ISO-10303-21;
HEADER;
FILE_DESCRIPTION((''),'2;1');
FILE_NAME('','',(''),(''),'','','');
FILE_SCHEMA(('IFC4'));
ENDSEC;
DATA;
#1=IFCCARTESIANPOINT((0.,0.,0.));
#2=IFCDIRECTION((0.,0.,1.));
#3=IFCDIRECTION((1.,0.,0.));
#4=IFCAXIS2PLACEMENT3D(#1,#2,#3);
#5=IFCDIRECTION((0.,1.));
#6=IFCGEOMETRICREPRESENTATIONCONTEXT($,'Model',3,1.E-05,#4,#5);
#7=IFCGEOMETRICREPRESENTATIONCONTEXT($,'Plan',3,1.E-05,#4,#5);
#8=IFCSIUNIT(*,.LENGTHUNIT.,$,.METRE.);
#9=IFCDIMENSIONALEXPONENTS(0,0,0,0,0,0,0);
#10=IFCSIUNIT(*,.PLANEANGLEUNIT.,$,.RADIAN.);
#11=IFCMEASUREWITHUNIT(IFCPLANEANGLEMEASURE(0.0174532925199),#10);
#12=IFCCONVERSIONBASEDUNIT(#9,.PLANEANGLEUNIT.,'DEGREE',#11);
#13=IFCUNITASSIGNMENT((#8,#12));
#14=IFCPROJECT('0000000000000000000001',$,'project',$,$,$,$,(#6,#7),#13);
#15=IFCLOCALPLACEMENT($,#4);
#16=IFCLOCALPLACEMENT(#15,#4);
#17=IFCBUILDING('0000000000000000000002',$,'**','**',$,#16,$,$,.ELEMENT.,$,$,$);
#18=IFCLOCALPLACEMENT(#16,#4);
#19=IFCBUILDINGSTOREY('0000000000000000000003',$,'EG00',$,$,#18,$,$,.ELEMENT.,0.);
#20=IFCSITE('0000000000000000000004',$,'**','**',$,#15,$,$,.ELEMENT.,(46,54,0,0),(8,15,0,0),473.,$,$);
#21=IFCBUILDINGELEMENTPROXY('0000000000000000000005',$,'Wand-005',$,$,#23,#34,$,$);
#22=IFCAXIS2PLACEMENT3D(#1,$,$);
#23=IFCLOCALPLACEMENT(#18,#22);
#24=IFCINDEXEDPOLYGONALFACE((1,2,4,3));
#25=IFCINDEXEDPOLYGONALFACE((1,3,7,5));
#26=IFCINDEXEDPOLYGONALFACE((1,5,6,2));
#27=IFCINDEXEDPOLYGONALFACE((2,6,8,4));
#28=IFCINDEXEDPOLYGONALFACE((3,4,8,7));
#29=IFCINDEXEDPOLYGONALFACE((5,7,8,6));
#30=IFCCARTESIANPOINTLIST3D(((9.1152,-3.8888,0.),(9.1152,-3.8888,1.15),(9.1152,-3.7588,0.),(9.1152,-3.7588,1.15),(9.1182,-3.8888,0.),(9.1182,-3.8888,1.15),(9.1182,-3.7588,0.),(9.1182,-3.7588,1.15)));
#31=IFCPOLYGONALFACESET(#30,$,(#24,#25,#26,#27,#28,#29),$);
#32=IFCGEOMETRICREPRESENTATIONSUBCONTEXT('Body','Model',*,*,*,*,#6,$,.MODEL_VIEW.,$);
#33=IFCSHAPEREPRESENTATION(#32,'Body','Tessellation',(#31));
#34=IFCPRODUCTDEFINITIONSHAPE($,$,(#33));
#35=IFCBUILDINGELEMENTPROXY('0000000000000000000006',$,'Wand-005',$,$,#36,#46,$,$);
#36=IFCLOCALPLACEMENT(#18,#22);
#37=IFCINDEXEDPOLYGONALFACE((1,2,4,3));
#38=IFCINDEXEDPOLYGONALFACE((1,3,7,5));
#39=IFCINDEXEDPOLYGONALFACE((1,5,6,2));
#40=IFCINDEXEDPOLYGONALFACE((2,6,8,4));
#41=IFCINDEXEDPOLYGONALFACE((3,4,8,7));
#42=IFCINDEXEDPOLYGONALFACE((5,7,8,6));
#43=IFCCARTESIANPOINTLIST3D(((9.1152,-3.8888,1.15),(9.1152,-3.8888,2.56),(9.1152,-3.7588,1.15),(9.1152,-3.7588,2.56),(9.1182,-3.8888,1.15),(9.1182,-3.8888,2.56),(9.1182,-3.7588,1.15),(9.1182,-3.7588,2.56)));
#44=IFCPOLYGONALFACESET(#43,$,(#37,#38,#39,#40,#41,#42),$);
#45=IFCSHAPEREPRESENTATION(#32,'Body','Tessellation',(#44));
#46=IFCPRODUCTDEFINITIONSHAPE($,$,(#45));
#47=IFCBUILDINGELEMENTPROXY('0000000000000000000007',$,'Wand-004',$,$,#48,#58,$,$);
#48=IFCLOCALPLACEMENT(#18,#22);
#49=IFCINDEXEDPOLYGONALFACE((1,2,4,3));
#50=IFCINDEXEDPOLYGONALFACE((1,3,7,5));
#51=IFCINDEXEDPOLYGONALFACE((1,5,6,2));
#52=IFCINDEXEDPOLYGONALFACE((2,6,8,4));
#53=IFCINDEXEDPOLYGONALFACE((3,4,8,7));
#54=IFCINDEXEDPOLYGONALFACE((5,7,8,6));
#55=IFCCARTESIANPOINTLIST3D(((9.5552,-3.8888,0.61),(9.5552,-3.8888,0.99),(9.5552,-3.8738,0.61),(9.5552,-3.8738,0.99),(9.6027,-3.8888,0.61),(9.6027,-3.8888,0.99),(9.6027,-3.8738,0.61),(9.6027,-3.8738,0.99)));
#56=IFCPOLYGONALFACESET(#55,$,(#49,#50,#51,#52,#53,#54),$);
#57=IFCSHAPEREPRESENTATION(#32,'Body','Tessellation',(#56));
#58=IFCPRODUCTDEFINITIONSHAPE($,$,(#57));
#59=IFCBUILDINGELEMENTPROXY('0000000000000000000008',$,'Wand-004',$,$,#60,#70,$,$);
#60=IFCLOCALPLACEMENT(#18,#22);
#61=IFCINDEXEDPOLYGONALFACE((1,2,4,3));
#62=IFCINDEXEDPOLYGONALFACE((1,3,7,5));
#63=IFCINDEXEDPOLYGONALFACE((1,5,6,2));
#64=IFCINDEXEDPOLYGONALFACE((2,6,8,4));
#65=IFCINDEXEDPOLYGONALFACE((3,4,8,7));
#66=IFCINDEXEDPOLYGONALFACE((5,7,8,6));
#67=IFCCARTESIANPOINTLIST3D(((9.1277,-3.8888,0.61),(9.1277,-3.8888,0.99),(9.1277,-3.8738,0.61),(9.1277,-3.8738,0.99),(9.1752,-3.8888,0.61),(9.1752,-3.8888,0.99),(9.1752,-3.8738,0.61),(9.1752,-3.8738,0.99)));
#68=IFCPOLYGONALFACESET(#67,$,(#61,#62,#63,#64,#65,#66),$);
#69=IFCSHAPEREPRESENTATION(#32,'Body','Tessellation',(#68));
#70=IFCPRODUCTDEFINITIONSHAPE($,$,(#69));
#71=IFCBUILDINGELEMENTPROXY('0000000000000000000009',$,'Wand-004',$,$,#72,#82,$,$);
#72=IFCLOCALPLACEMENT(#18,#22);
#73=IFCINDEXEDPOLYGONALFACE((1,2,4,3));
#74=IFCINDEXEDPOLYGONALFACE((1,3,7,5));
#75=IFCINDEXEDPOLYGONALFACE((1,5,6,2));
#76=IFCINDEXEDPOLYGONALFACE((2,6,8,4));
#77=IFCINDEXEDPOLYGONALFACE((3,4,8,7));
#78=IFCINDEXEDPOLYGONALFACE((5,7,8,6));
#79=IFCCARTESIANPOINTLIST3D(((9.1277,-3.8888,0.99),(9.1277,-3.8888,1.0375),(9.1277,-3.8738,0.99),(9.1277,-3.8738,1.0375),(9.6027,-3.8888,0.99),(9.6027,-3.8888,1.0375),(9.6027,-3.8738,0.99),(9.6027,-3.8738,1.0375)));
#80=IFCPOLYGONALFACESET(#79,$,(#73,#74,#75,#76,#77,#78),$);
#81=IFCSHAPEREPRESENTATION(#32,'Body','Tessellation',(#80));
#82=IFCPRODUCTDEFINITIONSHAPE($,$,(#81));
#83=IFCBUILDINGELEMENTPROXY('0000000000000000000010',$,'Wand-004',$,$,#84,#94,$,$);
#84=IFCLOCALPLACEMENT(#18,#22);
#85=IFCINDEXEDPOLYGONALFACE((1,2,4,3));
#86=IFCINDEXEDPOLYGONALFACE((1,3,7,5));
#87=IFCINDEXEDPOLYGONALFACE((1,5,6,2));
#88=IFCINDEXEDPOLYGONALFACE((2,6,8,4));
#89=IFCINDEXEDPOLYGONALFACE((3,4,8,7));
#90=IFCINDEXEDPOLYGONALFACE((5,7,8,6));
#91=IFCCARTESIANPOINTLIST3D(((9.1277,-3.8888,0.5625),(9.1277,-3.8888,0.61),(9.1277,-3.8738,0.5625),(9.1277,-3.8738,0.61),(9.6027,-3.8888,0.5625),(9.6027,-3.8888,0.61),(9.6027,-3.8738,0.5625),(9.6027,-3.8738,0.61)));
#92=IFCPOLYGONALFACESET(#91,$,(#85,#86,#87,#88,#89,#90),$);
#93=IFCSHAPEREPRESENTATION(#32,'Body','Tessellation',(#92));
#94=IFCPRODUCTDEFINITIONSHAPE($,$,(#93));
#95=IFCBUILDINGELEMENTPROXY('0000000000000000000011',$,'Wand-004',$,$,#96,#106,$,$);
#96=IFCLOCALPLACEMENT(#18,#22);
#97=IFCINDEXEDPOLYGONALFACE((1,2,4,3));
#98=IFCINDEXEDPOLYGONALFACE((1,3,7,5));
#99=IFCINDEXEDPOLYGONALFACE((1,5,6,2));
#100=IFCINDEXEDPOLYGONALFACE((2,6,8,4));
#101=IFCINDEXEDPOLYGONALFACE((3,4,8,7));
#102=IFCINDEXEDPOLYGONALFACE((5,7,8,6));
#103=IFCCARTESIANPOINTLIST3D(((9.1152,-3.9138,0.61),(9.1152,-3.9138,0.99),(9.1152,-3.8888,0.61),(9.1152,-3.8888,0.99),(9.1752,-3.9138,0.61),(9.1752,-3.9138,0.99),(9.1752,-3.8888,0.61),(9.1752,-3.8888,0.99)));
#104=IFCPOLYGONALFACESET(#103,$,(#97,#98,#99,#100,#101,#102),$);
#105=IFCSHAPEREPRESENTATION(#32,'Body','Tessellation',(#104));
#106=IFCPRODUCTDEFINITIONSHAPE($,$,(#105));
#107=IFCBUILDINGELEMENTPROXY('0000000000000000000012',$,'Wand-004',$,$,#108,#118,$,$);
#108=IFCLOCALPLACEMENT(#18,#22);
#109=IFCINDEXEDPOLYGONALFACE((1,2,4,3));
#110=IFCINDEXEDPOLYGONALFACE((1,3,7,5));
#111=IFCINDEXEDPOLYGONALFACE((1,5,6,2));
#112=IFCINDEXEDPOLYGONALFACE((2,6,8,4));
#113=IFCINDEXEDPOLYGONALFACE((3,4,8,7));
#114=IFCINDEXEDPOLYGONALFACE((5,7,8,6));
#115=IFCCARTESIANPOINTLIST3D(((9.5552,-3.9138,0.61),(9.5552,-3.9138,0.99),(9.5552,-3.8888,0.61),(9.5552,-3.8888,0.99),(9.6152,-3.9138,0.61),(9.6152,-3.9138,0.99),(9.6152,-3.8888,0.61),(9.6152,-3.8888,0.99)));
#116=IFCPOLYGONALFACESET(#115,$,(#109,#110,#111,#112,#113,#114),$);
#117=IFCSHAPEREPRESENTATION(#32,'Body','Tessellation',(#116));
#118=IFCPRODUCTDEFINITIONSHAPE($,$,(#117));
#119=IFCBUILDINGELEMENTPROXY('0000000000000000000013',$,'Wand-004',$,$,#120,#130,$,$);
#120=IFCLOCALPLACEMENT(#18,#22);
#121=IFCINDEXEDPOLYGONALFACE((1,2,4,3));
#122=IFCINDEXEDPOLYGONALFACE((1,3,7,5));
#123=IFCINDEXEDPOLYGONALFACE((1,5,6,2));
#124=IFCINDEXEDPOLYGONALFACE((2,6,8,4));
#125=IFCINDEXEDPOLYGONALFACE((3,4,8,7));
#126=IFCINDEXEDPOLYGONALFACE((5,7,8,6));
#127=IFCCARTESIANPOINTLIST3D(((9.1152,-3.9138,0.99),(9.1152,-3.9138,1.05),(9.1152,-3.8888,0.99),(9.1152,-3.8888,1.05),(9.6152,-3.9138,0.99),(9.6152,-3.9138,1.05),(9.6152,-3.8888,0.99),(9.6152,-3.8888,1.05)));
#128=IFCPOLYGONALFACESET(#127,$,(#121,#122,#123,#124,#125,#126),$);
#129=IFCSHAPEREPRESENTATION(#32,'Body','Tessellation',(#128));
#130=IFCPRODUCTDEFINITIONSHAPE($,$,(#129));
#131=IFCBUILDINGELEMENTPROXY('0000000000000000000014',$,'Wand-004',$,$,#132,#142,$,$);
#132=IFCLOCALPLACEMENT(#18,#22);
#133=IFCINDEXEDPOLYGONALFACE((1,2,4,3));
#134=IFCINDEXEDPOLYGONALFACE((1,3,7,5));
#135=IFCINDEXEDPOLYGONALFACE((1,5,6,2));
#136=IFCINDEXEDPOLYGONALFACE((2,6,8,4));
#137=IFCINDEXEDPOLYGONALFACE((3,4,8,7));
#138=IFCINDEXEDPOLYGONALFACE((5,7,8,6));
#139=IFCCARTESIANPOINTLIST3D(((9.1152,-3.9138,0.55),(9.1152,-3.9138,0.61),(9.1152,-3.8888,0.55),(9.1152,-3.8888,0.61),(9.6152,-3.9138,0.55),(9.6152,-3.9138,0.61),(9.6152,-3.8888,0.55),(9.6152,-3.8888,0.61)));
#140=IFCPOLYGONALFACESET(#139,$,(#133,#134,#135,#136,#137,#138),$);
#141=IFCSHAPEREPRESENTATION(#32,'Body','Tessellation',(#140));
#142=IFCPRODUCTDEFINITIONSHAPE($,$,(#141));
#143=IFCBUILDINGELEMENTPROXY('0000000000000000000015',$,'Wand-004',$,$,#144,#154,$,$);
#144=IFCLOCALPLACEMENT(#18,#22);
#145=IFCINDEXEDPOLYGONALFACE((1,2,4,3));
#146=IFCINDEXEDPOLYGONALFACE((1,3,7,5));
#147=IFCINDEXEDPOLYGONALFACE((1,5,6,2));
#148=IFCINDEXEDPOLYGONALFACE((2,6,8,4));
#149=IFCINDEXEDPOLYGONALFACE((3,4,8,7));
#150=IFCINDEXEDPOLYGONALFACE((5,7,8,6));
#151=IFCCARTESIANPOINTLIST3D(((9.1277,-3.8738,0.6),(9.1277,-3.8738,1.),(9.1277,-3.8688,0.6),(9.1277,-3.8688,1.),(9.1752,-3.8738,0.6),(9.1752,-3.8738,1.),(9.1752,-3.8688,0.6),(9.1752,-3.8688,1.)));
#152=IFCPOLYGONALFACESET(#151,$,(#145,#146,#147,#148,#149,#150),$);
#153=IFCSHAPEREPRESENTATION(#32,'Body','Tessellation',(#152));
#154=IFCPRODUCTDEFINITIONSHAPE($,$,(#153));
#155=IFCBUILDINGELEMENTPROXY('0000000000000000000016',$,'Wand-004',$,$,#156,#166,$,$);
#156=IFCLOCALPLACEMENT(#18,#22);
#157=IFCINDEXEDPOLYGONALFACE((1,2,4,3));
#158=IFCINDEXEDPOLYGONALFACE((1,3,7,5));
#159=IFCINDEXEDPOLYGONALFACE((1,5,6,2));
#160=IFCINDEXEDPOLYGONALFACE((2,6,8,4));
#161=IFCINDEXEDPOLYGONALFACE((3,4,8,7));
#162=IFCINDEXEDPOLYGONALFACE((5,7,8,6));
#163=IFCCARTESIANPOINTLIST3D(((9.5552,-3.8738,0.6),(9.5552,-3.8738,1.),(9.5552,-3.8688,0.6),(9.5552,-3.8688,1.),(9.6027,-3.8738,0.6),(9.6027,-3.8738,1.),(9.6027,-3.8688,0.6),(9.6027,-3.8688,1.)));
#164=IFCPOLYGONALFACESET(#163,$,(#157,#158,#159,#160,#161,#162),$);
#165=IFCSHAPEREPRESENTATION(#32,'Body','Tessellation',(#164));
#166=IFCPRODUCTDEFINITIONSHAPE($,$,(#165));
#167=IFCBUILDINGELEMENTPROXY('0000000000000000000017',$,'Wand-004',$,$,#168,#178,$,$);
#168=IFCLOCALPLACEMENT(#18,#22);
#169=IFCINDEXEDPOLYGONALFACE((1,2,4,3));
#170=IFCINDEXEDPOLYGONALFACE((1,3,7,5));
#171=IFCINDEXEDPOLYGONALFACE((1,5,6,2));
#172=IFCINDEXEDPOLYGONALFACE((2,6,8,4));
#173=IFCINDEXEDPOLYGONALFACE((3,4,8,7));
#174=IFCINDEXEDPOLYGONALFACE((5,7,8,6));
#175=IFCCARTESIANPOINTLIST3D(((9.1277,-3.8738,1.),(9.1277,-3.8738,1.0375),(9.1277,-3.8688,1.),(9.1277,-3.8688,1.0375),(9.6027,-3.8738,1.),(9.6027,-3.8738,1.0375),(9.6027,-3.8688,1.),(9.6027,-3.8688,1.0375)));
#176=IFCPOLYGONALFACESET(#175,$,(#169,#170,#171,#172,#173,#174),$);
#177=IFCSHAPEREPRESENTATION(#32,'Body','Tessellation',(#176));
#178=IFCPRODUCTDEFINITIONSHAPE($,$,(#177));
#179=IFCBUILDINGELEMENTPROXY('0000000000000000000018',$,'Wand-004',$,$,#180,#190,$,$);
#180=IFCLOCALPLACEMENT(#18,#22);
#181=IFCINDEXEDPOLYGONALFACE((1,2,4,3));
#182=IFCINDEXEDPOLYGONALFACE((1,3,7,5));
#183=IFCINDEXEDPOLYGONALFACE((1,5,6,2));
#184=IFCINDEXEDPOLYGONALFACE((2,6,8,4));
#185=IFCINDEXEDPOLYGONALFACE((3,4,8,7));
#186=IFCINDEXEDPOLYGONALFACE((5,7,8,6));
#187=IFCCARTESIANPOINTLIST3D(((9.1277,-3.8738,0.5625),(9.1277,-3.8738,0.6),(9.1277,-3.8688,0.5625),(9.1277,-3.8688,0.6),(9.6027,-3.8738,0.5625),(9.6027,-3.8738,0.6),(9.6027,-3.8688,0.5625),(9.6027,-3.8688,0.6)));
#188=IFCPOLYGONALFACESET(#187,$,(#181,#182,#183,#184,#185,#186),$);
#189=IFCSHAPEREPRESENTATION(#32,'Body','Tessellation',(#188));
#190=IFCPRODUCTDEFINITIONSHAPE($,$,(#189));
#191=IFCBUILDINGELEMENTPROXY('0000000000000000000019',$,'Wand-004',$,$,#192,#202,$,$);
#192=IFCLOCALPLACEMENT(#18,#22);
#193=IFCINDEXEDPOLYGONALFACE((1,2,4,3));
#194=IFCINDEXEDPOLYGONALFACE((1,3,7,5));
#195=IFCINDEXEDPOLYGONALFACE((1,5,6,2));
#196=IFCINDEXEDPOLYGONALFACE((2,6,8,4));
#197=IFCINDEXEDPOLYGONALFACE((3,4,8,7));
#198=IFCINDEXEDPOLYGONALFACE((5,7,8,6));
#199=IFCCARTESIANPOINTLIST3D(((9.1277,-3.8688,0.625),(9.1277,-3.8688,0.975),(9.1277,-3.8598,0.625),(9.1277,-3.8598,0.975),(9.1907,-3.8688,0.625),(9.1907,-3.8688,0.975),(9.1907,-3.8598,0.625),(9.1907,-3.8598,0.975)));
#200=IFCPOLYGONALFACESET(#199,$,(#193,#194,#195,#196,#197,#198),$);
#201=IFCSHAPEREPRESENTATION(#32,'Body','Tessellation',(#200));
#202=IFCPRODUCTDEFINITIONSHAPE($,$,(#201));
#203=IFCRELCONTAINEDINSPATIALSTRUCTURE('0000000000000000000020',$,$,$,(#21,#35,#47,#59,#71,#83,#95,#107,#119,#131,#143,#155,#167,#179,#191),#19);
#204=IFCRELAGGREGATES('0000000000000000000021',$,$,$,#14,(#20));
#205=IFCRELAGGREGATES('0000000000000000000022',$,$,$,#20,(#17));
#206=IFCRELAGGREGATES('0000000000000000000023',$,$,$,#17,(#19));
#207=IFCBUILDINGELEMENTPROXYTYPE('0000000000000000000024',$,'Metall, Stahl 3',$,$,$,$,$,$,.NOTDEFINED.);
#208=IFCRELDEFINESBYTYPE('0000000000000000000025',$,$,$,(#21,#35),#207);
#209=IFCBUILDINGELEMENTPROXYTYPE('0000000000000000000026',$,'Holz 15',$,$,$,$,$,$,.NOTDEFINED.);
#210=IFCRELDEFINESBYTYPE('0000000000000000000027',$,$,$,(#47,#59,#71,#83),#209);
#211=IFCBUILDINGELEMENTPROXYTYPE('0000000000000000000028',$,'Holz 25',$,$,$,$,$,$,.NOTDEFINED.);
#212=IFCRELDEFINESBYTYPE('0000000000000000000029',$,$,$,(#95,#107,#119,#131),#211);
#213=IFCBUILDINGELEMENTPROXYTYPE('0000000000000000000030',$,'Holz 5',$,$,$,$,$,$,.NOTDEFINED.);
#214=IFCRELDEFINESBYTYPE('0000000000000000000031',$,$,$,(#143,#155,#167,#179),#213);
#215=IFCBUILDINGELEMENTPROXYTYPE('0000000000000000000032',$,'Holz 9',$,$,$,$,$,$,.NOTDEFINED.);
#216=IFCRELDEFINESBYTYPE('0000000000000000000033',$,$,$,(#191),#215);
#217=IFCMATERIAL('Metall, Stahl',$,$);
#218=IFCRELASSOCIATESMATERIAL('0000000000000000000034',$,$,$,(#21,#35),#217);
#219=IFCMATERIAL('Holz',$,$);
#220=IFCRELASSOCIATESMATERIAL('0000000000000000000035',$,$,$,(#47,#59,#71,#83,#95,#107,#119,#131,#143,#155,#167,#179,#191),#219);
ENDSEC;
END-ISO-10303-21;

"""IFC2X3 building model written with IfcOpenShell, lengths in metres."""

from ifc_helpers import new_model, entity, si_unit, converted_unit, direction, frame, origin_with_axes, place, context, subcontext, project, spatial, polyline, outline, extrude, material, type_object, element, save


model = new_model("IFC2X3")

# Units and contexts
model_context = context("Model", 3, precision=1e-05, world=origin_with_axes(), true_north=direction((0.0, 1.0)))
plan_context = context("Plan", 3, precision=1e-05, world=origin_with_axes(), true_north=direction((0.0, 1.0)))
body_context = subcontext(model_context, "Body", "Model", "MODEL_VIEW")
ifc_project = project(units=[si_unit("LENGTHUNIT", "METRE"), converted_unit("PLANEANGLEUNIT", "DEGREE", entity("IfcPlaneAngleMeasure", 0.0174532925199), si_unit("PLANEANGLEUNIT", "RADIAN"), dimensions=[0, 0, 0, 0, 0, 0, 0])], contexts=[model_context, plan_context])

# Site, building, storey
site_placement = place(None, origin_with_axes())
site = spatial("IfcSite", under=ifc_project, at=site_placement, Name="**", Description="**", CompositionType="ELEMENT", RefLatitude=(46, 54, 0, 0), RefLongitude=(8, 15, 0, 0), RefElevation=473.0)
building_placement = place(site_placement, origin_with_axes())
building = spatial("IfcBuilding", under=site, at=building_placement, Name="**", Description="**", CompositionType="ELEMENT")
storey_placement = place(building_placement, origin_with_axes())
storey = spatial("IfcBuildingStorey", under=building, at=storey_placement, Name="EG00", CompositionType="ELEMENT", Elevation=0.0)

# Building element proxies
ifc_material_1 = material(Name="Metall, Stahl")
building_element_proxy_type_1 = type_object("IfcBuildingElementProxyType", Name="Metall, Stahl 3", PredefinedType="NOTDEFINED")
proxy_1_placement = place(storey_placement, frame((9.1152, -3.7588, 0.0), z_axis=(0.0, 0.0, 1.0), x_axis=(0.0, -1.0, 0.0)))
element("IfcBuildingElementProxy", 1, at=proxy_1_placement, inside=storey, type_object=building_element_proxy_type_1, material=ifc_material_1, Name="Wand-005", context=body_context, shape_type="SweptSolid", body=[
    extrude(outline(polyline([(0.0, 0.0), (0.13, 0.0), (0.13, 0.003), (0.0, 0.003), (0.0, 0.0)])), origin_with_axes(), (0.0, 0.0, 1.0), 1.15),
])
proxy_2_placement = place(storey_placement, frame((9.1152, -3.7588, 1.15), z_axis=(0.0, 0.0, 1.0), x_axis=(0.0, -1.0, 0.0)))
element("IfcBuildingElementProxy", 2, at=proxy_2_placement, inside=storey, type_object=building_element_proxy_type_1, material=ifc_material_1, Name="Wand-005", context=body_context, shape_type="SweptSolid", body=[
    extrude(outline(polyline([(0.0, 0.0), (0.13, 0.0), (0.13, 0.003), (0.0, 0.003), (0.0, 0.0)])), origin_with_axes(), (0.0, 0.0, 1.0), 1.41),
])
ifc_material_2 = material(Name="Holz")
building_element_proxy_type_2 = type_object("IfcBuildingElementProxyType", Name="Holz 15", PredefinedType="NOTDEFINED")
for number, where, z_axis, x_axis, name in (
    (3, (9.5552, -3.8888, 0.61), (0.0, 0.0, 1.0), (1.0, 0.0, 0.0), "Wand-004"),
    (4, (9.1277, -3.8888, 0.61), (0.0, 0.0, 1.0), (1.0, 0.0, 0.0), "Wand-004"),
):
    element("IfcBuildingElementProxy", number, at=place(storey_placement, frame(where, z_axis=z_axis, x_axis=x_axis)), inside=storey, type_object=building_element_proxy_type_2, material=ifc_material_2, Name=name, context=body_context, shape_type="SweptSolid", body=[
        extrude(outline(polyline([(0.0, 0.0), (0.0475, 0.0), (0.0475, 0.015), (0.0, 0.015), (0.0, 0.0)])), origin_with_axes(), (0.0, 0.0, 1.0), 0.38),
    ])
for number, where, z_axis, x_axis, name in (
    (5, (9.6027, -3.8738, 0.99), (0.0, 0.0, 1.0), (-1.0, 0.0, 0.0), "Wand-004"),
    (6, (9.6027, -3.8738, 0.5625), (0.0, 0.0, 1.0), (-1.0, 0.0, 0.0), "Wand-004"),
):
    element("IfcBuildingElementProxy", number, at=place(storey_placement, frame(where, z_axis=z_axis, x_axis=x_axis)), inside=storey, type_object=building_element_proxy_type_2, material=ifc_material_2, Name=name, context=body_context, shape_type="SweptSolid", body=[
        extrude(outline(polyline([(0.0, 0.0), (0.475, 0.0), (0.475, 0.015), (0.0, 0.015), (0.0, 0.0)])), origin_with_axes(), (0.0, 0.0, 1.0), 0.0475),
    ])
building_element_proxy_type_3 = type_object("IfcBuildingElementProxyType", Name="Holz 25", PredefinedType="NOTDEFINED")
for number, where, z_axis, x_axis, name in (
    (7, (9.1152, -3.9138, 0.61), (0.0, 0.0, 1.0), (1.0, 0.0, 0.0), "Wand-004"),
    (8, (9.5552, -3.9138, 0.61), (0.0, 0.0, 1.0), (1.0, 0.0, 0.0), "Wand-004"),
):
    element("IfcBuildingElementProxy", number, at=place(storey_placement, frame(where, z_axis=z_axis, x_axis=x_axis)), inside=storey, type_object=building_element_proxy_type_3, material=ifc_material_2, Name=name, context=body_context, shape_type="SweptSolid", body=[
        extrude(outline(polyline([(0.0, 0.0), (0.06, 0.0), (0.06, 0.025), (0.0, 0.025), (0.0, 0.0)])), origin_with_axes(), (0.0, 0.0, 1.0), 0.38),
    ])
for number, where, z_axis, x_axis, name in (
    (9, (9.6152, -3.8888, 0.99), (0.0, 0.0, 1.0), (-1.0, 0.0, 0.0), "Wand-004"),
    (10, (9.6152, -3.8888, 0.55), (0.0, 0.0, 1.0), (-1.0, 0.0, 0.0), "Wand-004"),
):
    element("IfcBuildingElementProxy", number, at=place(storey_placement, frame(where, z_axis=z_axis, x_axis=x_axis)), inside=storey, type_object=building_element_proxy_type_3, material=ifc_material_2, Name=name, context=body_context, shape_type="SweptSolid", body=[
        extrude(outline(polyline([(0.0, 0.0), (0.5, 0.0), (0.5, 0.025), (0.0, 0.025), (0.0, 0.0)])), origin_with_axes(), (0.0, 0.0, 1.0), 0.06),
    ])
building_element_proxy_type_4 = type_object("IfcBuildingElementProxyType", Name="Holz 5", PredefinedType="NOTDEFINED")
for number, where, z_axis, x_axis, name in (
    (11, (9.1277, -3.8738, 0.6), (0.0, 0.0, 1.0), (1.0, 0.0, 0.0), "Wand-004"),
    (12, (9.5552, -3.8738, 0.6), (0.0, 0.0, 1.0), (1.0, 0.0, 0.0), "Wand-004"),
):
    element("IfcBuildingElementProxy", number, at=place(storey_placement, frame(where, z_axis=z_axis, x_axis=x_axis)), inside=storey, type_object=building_element_proxy_type_4, material=ifc_material_2, Name=name, context=body_context, shape_type="SweptSolid", body=[
        extrude(outline(polyline([(0.0, 0.0), (0.0475, 0.0), (0.0475, 0.005), (0.0, 0.005), (0.0, 0.0)])), origin_with_axes(), (0.0, 0.0, 1.0), 0.4),
    ])
for number, where, z_axis, x_axis, name in (
    (13, (9.6027, -3.8738, 1.0), (0.0, 0.0, 1.0), (-1.0, 0.0, 0.0), "Wand-004"),
    (14, (9.6027, -3.8738, 0.5625), (0.0, 0.0, 1.0), (-1.0, 0.0, 0.0), "Wand-004"),
):
    element("IfcBuildingElementProxy", number, at=place(storey_placement, frame(where, z_axis=z_axis, x_axis=x_axis)), inside=storey, type_object=building_element_proxy_type_4, material=ifc_material_2, Name=name, context=body_context, shape_type="SweptSolid", body=[
        extrude(outline(polyline([(0.0, -0.005), (0.475, -0.005), (0.475, 0.0), (0.0, 0.0), (0.0, -0.005)])), origin_with_axes(), (0.0, 0.0, 1.0), 0.0375),
    ])
building_element_proxy_type_5 = type_object("IfcBuildingElementProxyType", Name="Holz 9", PredefinedType="NOTDEFINED")
for number, where, z_axis, x_axis, name in (
    (15, (9.1277, -3.8688, 0.625), (0.0, 0.0, 1.0), (1.0, 0.0, 0.0), "Wand-004"),
):
    element("IfcBuildingElementProxy", number, at=place(storey_placement, frame(where, z_axis=z_axis, x_axis=x_axis)), inside=storey, type_object=building_element_proxy_type_5, material=ifc_material_2, Name=name, context=body_context, shape_type="SweptSolid", body=[
        extrude(outline(polyline([(0.0, 0.0), (0.063, 0.0), (0.063, 0.009), (0.0, 0.009), (0.0, 0.0)])), origin_with_axes(), (0.0, 0.0, 1.0), 0.35),
    ])

save(model, "model.ifc")
